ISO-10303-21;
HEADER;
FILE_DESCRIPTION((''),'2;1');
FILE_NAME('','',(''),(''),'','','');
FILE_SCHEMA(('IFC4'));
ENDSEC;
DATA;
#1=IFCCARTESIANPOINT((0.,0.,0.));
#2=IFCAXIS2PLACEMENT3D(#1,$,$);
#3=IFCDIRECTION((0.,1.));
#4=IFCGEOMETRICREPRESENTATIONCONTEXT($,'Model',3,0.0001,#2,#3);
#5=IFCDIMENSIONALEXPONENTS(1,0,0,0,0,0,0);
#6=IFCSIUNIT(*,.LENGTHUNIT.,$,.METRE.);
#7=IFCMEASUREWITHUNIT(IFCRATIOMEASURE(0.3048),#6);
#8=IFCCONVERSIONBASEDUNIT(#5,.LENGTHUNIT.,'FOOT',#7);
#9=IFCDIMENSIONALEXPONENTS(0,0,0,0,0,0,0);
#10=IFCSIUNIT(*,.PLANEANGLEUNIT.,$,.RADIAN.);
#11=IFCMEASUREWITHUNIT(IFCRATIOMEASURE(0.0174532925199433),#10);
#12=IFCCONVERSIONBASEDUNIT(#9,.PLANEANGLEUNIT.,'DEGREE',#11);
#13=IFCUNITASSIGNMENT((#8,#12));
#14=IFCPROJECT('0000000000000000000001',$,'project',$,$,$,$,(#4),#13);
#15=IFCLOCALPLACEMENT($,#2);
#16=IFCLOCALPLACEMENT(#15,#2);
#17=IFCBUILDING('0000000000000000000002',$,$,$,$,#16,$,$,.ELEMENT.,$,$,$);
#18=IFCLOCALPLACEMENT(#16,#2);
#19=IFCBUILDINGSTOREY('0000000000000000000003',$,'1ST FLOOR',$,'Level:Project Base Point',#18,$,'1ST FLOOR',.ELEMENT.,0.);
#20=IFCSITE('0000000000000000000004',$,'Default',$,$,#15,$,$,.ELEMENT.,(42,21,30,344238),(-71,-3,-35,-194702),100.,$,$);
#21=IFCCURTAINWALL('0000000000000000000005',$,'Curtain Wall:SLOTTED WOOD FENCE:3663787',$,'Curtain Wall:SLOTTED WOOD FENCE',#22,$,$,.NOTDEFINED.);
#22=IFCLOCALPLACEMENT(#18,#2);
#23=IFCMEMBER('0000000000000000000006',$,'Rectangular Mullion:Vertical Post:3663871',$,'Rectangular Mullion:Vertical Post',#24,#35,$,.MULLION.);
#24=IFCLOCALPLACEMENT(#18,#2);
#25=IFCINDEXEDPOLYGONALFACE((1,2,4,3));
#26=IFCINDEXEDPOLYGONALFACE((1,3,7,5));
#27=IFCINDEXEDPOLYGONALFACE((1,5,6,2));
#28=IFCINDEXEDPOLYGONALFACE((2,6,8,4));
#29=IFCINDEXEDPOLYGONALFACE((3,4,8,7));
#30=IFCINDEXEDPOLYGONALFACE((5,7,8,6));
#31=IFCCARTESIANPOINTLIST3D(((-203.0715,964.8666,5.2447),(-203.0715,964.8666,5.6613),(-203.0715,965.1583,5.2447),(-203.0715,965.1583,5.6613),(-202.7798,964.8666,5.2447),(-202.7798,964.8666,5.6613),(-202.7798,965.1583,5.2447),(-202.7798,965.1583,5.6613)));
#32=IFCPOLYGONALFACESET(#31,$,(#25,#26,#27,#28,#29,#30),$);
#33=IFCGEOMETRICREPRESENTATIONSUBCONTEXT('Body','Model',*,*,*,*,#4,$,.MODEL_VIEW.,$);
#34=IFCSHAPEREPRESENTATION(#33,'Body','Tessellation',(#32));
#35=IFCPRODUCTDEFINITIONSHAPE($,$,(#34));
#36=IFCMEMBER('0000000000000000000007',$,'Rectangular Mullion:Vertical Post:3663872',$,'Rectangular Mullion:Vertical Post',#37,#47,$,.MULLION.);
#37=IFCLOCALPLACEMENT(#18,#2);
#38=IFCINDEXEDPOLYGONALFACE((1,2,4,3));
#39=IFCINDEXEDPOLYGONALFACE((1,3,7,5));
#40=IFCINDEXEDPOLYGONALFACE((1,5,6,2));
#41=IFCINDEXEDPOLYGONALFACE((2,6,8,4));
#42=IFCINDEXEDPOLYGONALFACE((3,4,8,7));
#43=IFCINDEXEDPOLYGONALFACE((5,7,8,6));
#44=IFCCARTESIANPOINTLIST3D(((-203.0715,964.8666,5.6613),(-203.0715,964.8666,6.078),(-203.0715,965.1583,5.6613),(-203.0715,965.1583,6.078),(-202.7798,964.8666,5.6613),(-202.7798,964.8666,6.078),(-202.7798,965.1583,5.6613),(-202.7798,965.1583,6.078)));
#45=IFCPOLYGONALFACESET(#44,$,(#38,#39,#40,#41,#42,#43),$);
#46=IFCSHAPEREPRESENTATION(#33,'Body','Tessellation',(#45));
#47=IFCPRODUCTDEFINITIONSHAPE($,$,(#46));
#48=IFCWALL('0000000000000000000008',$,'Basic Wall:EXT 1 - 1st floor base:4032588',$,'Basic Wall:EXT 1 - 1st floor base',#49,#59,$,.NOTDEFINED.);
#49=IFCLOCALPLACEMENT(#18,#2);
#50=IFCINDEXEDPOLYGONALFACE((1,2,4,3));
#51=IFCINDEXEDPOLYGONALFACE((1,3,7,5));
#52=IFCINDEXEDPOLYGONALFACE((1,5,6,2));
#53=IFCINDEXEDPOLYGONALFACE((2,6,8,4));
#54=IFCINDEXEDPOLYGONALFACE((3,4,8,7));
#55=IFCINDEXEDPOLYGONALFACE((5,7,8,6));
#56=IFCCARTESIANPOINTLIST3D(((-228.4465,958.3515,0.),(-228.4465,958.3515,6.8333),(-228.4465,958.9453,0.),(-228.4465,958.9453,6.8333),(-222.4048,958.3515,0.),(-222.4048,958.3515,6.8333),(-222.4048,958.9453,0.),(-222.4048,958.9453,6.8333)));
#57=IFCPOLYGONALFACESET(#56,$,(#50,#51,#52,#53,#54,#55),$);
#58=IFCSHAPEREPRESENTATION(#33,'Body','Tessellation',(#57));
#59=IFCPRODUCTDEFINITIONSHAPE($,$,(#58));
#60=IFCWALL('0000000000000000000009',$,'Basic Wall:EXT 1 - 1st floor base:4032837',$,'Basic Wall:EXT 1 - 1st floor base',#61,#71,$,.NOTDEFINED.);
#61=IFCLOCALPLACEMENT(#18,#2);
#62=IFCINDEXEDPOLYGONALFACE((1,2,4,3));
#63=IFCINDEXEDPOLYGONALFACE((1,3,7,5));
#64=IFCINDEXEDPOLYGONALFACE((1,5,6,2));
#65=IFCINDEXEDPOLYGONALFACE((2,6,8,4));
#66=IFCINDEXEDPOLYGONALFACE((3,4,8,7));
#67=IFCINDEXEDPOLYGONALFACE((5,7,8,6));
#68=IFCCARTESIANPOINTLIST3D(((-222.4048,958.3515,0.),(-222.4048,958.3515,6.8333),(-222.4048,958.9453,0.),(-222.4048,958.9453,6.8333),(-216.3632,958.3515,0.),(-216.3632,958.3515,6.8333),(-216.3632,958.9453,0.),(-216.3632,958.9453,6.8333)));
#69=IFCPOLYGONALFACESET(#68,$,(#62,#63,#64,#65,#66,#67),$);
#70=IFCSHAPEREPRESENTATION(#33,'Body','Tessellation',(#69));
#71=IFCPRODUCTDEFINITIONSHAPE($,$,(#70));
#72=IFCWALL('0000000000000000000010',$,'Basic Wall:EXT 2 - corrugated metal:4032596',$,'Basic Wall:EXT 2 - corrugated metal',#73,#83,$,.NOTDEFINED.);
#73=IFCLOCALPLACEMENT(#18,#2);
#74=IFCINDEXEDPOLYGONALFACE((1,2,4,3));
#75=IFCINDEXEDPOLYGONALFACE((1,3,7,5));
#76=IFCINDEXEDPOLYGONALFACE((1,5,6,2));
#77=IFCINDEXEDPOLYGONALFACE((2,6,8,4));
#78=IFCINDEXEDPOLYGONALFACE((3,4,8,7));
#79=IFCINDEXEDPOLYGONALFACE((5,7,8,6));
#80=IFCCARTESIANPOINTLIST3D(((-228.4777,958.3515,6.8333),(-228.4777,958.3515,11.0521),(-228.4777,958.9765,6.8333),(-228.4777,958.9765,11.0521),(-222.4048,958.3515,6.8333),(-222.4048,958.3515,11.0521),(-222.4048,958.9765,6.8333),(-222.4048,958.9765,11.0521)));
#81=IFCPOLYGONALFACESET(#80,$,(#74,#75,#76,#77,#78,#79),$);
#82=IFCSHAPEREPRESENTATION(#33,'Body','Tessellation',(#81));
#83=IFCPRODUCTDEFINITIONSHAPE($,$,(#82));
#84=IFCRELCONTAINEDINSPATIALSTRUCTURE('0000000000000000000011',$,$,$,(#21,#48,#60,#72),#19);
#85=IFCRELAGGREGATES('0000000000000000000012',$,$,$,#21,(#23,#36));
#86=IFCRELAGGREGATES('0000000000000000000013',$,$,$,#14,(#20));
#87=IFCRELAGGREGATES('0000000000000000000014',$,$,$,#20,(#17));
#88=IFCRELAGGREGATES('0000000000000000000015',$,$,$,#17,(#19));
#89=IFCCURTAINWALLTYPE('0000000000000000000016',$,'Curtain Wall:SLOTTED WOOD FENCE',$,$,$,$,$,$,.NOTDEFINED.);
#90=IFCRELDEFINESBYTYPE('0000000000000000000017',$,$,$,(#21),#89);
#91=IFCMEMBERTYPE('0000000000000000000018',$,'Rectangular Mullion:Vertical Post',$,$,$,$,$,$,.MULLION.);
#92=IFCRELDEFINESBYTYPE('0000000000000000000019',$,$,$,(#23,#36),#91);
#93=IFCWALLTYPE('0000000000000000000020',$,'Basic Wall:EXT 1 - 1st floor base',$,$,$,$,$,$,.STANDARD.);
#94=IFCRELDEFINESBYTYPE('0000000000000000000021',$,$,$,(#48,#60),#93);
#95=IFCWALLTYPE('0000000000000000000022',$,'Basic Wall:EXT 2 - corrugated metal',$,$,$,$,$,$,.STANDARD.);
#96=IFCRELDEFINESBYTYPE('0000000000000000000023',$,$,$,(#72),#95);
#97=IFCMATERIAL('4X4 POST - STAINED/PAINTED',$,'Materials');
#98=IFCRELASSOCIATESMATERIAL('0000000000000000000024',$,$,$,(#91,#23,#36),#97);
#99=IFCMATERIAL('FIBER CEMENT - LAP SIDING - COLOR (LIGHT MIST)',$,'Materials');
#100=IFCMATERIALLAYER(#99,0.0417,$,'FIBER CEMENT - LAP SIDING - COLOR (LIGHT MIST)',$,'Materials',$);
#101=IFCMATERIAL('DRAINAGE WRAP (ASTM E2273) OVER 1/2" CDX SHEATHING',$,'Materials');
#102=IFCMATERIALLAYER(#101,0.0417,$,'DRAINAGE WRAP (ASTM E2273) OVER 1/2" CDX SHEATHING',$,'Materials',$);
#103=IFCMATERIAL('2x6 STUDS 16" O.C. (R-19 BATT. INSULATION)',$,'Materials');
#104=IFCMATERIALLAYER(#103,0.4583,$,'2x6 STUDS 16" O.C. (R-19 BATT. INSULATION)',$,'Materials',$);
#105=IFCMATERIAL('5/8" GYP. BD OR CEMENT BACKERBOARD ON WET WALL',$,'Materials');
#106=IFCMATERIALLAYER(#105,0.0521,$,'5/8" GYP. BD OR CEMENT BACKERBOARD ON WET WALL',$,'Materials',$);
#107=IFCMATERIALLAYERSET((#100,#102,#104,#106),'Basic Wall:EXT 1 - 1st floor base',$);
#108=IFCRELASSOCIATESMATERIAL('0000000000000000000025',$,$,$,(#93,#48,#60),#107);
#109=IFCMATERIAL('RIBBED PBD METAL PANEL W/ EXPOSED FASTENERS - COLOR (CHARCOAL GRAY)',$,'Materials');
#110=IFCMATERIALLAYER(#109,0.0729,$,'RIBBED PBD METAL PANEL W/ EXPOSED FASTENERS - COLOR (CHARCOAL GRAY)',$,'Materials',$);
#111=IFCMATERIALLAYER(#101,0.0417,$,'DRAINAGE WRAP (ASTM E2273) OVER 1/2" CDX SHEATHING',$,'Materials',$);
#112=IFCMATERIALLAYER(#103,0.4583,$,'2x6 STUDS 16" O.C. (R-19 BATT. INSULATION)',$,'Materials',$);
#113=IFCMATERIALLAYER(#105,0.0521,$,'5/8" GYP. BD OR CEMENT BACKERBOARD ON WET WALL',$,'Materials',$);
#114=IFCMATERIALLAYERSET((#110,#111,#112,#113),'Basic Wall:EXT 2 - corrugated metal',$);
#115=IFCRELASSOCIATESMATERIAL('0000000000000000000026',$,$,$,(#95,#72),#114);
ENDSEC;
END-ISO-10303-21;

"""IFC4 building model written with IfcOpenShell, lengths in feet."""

from ifc_helpers import new_model, entity, si_unit, converted_unit, direction, frame, frame_2d, origin, origin_2d_with_axis, place, context, subcontext, project, spatial, rectangle, extrude, source, transform, mapped, material, layer, layer_set, layer_usage, material_profile, profile_set, profile_usage, type_object, type_shapes, element, aggregate, save


model = new_model("IFC4")

# Units and contexts
model_context = context("Model", 3, precision=0.0001, world=origin(), true_north=direction((0.0, 1.0)))
body_context = subcontext(model_context, "Body", "Model", "MODEL_VIEW")
ifc_project = project(units=[converted_unit("LENGTHUNIT", "FOOT", entity("IfcRatioMeasure", 0.3048), si_unit("LENGTHUNIT", "METRE"), dimensions=[1, 0, 0, 0, 0, 0, 0]), converted_unit("PLANEANGLEUNIT", "DEGREE", entity("IfcRatioMeasure", 0.0174532925199433), si_unit("PLANEANGLEUNIT", "RADIAN"), dimensions=[0, 0, 0, 0, 0, 0, 0])], contexts=[model_context])

# Site, building, storey
site_placement = place(None, origin())
site = spatial("IfcSite", under=ifc_project, at=site_placement, Name="Default", CompositionType="ELEMENT", RefLatitude=(42, 21, 30, 344238), RefLongitude=(-71, -3, -35, -194702), RefElevation=100.0)
building_placement = place(site_placement, origin())
building = spatial("IfcBuilding", under=site, at=building_placement, CompositionType="ELEMENT")
storey_placement = place(building_placement, origin())
storey = spatial("IfcBuildingStorey", under=building, at=storey_placement, Name="1ST FLOOR", ObjectType="Level:Project Base Point", LongName="1ST FLOOR", CompositionType="ELEMENT", Elevation=0.0)

# Curtain wall, members
curtain_wall_type = type_object("IfcCurtainWallType", Name="Curtain Wall:SLOTTED WOOD FENCE", PredefinedType="NOTDEFINED")
curtain_wall_placement = place(storey_placement, origin())
curtain_wall = element("IfcCurtainWall", 1, at=curtain_wall_placement, inside=storey, type_object=curtain_wall_type, Name="Curtain Wall:SLOTTED WOOD FENCE:3663787", ObjectType="Curtain Wall:SLOTTED WOOD FENCE", PredefinedType="NOTDEFINED")
ifc_material_1 = material(Name="4X4 POST - STAINED/PAINTED", Category="Materials")
ifc_material_profile = material_profile(ifc_material_1, rectangle(XDim=0.2917, YDim=0.2917, at=origin_2d_with_axis()), Name="Vertical Post")
ifc_profile_set = profile_set([ifc_material_profile], Name="Vertical Post")
member_type_1 = type_object("IfcMemberType", Name="Rectangular Mullion:Vertical Post", PredefinedType="MULLION", material=ifc_profile_set)
shared_shape_1 = source(origin(), body_context, "Body", "SweptSolid", [
    extrude(rectangle(XDim=0.2917, YDim=0.2917, at=origin_2d_with_axis()), frame((-0.1458, -0.2083, -0.4167), z_axis=(0.0, 0.0, 1.0), x_axis=(0.0, -1.0, 0.0)), (0.0, 0.0, 1.0), 0.4167),
])
type_shapes(member_type_1, [shared_shape_1])
ifc_profile_usage_1 = profile_usage(ifc_profile_set)
member_1_placement = place(storey_placement, frame((-203.134, 964.8666, 5.2447), z_axis=(0.0, 0.0, -1.0), x_axis=(0.0, -1.0, 0.0)))
member_1 = element("IfcMember", 2, at=member_1_placement, type_object=member_type_1, material=ifc_profile_usage_1, Name="Rectangular Mullion:Vertical Post:3663871", ObjectType="Rectangular Mullion:Vertical Post", PredefinedType="MULLION", context=body_context, shape_type="MappedRepresentation", body=[
    mapped(shared_shape_1, transform((0.0, 0.0, 0.0), scale=1.0)),
])
ifc_profile_usage_2 = profile_usage(ifc_profile_set)
member_2_placement = place(storey_placement, frame((-203.134, 964.8666, 5.6613), z_axis=(0.0, 0.0, -1.0), x_axis=(0.0, -1.0, 0.0)))
member_2 = element("IfcMember", 3, at=member_2_placement, type_object=member_type_1, material=ifc_profile_usage_2, Name="Rectangular Mullion:Vertical Post:3663872", ObjectType="Rectangular Mullion:Vertical Post", PredefinedType="MULLION", context=body_context, shape_type="MappedRepresentation", body=[
    mapped(shared_shape_1, transform((0.0, 0.0, 0.0), scale=1.0)),
])
aggregate(curtain_wall, [member_1, member_2])

# Walls
ifc_material_2 = material(Name="FIBER CEMENT - LAP SIDING - COLOR (LIGHT MIST)", Category="Materials")
ifc_layer_1 = layer(ifc_material_2, 0.0417, Name="FIBER CEMENT - LAP SIDING - COLOR (LIGHT MIST)", Category="Materials")
ifc_material_3 = material(Name="DRAINAGE WRAP (ASTM E2273) OVER 1/2\" CDX SHEATHING", Category="Materials")
ifc_layer_2 = layer(ifc_material_3, 0.0417, Name="DRAINAGE WRAP (ASTM E2273) OVER 1/2\" CDX SHEATHING", Category="Materials")
ifc_material_4 = material(Name="2x6 STUDS 16\" O.C. (R-19 BATT. INSULATION)", Category="Materials")
ifc_layer_3 = layer(ifc_material_4, 0.4583, Name="2x6 STUDS 16\" O.C. (R-19 BATT. INSULATION)", Category="Materials")
ifc_material_5 = material(Name="5/8\" GYP. BD OR CEMENT BACKERBOARD ON WET WALL", Category="Materials")
ifc_layer_4 = layer(ifc_material_5, 0.0521, Name="5/8\" GYP. BD OR CEMENT BACKERBOARD ON WET WALL", Category="Materials")
ifc_layer_set_1 = layer_set([ifc_layer_1, ifc_layer_2, ifc_layer_3, ifc_layer_4], Name="Basic Wall:EXT 1 - 1st floor base")
ifc_layer_usage_1 = layer_usage(ifc_layer_set_1, "AXIS2", "NEGATIVE", 0.2969)
wall_type_1 = type_object("IfcWallType", Name="Basic Wall:EXT 1 - 1st floor base", PredefinedType="STANDARD", material=ifc_layer_set_1)
wall_1_placement = place(storey_placement, frame((-228.4465, 958.6484, 0.0)))
element("IfcWall", 4, at=wall_1_placement, inside=storey, type_object=wall_type_1, material=ifc_layer_usage_1, Name="Basic Wall:EXT 1 - 1st floor base:4032588", ObjectType="Basic Wall:EXT 1 - 1st floor base", PredefinedType="NOTDEFINED", context=body_context, shape_type="SweptSolid", body=[
    extrude(rectangle(XDim=6.0417, YDim=0.5938, at=frame_2d((3.0208, 0.0), x_axis=(-1.0, 0.0))), origin(), (0.0, 0.0, 1.0), 6.8333),
])
ifc_layer_usage_2 = layer_usage(ifc_layer_set_1, "AXIS2", "POSITIVE", -0.2969)
wall_2_placement = place(storey_placement, frame((-216.3632, 958.6484, 0.0), z_axis=(0.0, 0.0, 1.0), x_axis=(-1.0, 0.0, 0.0)))
element("IfcWall", 5, at=wall_2_placement, inside=storey, type_object=wall_type_1, material=ifc_layer_usage_2, Name="Basic Wall:EXT 1 - 1st floor base:4032837", ObjectType="Basic Wall:EXT 1 - 1st floor base", PredefinedType="NOTDEFINED", context=body_context, shape_type="SweptSolid", body=[
    extrude(rectangle(XDim=6.0417, YDim=0.5938, at=frame_2d((3.0208, 0.0), x_axis=(-1.0, 0.0))), origin(), (0.0, 0.0, 1.0), 6.8333),
])
ifc_material_6 = material(Name="RIBBED PBD METAL PANEL W/ EXPOSED FASTENERS - COLOR (CHARCOAL GRAY)", Category="Materials")
ifc_layer_5 = layer(ifc_material_6, 0.0729, Name="RIBBED PBD METAL PANEL W/ EXPOSED FASTENERS - COLOR (CHARCOAL GRAY)", Category="Materials")
ifc_layer_6 = layer(ifc_material_3, 0.0417, Name="DRAINAGE WRAP (ASTM E2273) OVER 1/2\" CDX SHEATHING", Category="Materials")
ifc_layer_7 = layer(ifc_material_4, 0.4583, Name="2x6 STUDS 16\" O.C. (R-19 BATT. INSULATION)", Category="Materials")
ifc_layer_8 = layer(ifc_material_5, 0.0521, Name="5/8\" GYP. BD OR CEMENT BACKERBOARD ON WET WALL", Category="Materials")
ifc_layer_set_2 = layer_set([ifc_layer_5, ifc_layer_6, ifc_layer_7, ifc_layer_8], Name="Basic Wall:EXT 2 - corrugated metal")
ifc_layer_usage_3 = layer_usage(ifc_layer_set_2, "AXIS2", "NEGATIVE", 0.3125)
wall_type_2 = type_object("IfcWallType", Name="Basic Wall:EXT 2 - corrugated metal", PredefinedType="STANDARD", material=ifc_layer_set_2)
wall_3_placement = place(storey_placement, frame((-228.4777, 958.664, 6.8333)))
element("IfcWall", 6, at=wall_3_placement, inside=storey, type_object=wall_type_2, material=ifc_layer_usage_3, Name="Basic Wall:EXT 2 - corrugated metal:4032596", ObjectType="Basic Wall:EXT 2 - corrugated metal", PredefinedType="NOTDEFINED", context=body_context, shape_type="SweptSolid", body=[
    extrude(rectangle(XDim=6.0729, YDim=0.625, at=frame_2d((3.0365, 0.0), x_axis=(-1.0, 0.0))), origin(), (0.0, 0.0, 1.0), 4.2187),
])

save(model, "model.ifc")
